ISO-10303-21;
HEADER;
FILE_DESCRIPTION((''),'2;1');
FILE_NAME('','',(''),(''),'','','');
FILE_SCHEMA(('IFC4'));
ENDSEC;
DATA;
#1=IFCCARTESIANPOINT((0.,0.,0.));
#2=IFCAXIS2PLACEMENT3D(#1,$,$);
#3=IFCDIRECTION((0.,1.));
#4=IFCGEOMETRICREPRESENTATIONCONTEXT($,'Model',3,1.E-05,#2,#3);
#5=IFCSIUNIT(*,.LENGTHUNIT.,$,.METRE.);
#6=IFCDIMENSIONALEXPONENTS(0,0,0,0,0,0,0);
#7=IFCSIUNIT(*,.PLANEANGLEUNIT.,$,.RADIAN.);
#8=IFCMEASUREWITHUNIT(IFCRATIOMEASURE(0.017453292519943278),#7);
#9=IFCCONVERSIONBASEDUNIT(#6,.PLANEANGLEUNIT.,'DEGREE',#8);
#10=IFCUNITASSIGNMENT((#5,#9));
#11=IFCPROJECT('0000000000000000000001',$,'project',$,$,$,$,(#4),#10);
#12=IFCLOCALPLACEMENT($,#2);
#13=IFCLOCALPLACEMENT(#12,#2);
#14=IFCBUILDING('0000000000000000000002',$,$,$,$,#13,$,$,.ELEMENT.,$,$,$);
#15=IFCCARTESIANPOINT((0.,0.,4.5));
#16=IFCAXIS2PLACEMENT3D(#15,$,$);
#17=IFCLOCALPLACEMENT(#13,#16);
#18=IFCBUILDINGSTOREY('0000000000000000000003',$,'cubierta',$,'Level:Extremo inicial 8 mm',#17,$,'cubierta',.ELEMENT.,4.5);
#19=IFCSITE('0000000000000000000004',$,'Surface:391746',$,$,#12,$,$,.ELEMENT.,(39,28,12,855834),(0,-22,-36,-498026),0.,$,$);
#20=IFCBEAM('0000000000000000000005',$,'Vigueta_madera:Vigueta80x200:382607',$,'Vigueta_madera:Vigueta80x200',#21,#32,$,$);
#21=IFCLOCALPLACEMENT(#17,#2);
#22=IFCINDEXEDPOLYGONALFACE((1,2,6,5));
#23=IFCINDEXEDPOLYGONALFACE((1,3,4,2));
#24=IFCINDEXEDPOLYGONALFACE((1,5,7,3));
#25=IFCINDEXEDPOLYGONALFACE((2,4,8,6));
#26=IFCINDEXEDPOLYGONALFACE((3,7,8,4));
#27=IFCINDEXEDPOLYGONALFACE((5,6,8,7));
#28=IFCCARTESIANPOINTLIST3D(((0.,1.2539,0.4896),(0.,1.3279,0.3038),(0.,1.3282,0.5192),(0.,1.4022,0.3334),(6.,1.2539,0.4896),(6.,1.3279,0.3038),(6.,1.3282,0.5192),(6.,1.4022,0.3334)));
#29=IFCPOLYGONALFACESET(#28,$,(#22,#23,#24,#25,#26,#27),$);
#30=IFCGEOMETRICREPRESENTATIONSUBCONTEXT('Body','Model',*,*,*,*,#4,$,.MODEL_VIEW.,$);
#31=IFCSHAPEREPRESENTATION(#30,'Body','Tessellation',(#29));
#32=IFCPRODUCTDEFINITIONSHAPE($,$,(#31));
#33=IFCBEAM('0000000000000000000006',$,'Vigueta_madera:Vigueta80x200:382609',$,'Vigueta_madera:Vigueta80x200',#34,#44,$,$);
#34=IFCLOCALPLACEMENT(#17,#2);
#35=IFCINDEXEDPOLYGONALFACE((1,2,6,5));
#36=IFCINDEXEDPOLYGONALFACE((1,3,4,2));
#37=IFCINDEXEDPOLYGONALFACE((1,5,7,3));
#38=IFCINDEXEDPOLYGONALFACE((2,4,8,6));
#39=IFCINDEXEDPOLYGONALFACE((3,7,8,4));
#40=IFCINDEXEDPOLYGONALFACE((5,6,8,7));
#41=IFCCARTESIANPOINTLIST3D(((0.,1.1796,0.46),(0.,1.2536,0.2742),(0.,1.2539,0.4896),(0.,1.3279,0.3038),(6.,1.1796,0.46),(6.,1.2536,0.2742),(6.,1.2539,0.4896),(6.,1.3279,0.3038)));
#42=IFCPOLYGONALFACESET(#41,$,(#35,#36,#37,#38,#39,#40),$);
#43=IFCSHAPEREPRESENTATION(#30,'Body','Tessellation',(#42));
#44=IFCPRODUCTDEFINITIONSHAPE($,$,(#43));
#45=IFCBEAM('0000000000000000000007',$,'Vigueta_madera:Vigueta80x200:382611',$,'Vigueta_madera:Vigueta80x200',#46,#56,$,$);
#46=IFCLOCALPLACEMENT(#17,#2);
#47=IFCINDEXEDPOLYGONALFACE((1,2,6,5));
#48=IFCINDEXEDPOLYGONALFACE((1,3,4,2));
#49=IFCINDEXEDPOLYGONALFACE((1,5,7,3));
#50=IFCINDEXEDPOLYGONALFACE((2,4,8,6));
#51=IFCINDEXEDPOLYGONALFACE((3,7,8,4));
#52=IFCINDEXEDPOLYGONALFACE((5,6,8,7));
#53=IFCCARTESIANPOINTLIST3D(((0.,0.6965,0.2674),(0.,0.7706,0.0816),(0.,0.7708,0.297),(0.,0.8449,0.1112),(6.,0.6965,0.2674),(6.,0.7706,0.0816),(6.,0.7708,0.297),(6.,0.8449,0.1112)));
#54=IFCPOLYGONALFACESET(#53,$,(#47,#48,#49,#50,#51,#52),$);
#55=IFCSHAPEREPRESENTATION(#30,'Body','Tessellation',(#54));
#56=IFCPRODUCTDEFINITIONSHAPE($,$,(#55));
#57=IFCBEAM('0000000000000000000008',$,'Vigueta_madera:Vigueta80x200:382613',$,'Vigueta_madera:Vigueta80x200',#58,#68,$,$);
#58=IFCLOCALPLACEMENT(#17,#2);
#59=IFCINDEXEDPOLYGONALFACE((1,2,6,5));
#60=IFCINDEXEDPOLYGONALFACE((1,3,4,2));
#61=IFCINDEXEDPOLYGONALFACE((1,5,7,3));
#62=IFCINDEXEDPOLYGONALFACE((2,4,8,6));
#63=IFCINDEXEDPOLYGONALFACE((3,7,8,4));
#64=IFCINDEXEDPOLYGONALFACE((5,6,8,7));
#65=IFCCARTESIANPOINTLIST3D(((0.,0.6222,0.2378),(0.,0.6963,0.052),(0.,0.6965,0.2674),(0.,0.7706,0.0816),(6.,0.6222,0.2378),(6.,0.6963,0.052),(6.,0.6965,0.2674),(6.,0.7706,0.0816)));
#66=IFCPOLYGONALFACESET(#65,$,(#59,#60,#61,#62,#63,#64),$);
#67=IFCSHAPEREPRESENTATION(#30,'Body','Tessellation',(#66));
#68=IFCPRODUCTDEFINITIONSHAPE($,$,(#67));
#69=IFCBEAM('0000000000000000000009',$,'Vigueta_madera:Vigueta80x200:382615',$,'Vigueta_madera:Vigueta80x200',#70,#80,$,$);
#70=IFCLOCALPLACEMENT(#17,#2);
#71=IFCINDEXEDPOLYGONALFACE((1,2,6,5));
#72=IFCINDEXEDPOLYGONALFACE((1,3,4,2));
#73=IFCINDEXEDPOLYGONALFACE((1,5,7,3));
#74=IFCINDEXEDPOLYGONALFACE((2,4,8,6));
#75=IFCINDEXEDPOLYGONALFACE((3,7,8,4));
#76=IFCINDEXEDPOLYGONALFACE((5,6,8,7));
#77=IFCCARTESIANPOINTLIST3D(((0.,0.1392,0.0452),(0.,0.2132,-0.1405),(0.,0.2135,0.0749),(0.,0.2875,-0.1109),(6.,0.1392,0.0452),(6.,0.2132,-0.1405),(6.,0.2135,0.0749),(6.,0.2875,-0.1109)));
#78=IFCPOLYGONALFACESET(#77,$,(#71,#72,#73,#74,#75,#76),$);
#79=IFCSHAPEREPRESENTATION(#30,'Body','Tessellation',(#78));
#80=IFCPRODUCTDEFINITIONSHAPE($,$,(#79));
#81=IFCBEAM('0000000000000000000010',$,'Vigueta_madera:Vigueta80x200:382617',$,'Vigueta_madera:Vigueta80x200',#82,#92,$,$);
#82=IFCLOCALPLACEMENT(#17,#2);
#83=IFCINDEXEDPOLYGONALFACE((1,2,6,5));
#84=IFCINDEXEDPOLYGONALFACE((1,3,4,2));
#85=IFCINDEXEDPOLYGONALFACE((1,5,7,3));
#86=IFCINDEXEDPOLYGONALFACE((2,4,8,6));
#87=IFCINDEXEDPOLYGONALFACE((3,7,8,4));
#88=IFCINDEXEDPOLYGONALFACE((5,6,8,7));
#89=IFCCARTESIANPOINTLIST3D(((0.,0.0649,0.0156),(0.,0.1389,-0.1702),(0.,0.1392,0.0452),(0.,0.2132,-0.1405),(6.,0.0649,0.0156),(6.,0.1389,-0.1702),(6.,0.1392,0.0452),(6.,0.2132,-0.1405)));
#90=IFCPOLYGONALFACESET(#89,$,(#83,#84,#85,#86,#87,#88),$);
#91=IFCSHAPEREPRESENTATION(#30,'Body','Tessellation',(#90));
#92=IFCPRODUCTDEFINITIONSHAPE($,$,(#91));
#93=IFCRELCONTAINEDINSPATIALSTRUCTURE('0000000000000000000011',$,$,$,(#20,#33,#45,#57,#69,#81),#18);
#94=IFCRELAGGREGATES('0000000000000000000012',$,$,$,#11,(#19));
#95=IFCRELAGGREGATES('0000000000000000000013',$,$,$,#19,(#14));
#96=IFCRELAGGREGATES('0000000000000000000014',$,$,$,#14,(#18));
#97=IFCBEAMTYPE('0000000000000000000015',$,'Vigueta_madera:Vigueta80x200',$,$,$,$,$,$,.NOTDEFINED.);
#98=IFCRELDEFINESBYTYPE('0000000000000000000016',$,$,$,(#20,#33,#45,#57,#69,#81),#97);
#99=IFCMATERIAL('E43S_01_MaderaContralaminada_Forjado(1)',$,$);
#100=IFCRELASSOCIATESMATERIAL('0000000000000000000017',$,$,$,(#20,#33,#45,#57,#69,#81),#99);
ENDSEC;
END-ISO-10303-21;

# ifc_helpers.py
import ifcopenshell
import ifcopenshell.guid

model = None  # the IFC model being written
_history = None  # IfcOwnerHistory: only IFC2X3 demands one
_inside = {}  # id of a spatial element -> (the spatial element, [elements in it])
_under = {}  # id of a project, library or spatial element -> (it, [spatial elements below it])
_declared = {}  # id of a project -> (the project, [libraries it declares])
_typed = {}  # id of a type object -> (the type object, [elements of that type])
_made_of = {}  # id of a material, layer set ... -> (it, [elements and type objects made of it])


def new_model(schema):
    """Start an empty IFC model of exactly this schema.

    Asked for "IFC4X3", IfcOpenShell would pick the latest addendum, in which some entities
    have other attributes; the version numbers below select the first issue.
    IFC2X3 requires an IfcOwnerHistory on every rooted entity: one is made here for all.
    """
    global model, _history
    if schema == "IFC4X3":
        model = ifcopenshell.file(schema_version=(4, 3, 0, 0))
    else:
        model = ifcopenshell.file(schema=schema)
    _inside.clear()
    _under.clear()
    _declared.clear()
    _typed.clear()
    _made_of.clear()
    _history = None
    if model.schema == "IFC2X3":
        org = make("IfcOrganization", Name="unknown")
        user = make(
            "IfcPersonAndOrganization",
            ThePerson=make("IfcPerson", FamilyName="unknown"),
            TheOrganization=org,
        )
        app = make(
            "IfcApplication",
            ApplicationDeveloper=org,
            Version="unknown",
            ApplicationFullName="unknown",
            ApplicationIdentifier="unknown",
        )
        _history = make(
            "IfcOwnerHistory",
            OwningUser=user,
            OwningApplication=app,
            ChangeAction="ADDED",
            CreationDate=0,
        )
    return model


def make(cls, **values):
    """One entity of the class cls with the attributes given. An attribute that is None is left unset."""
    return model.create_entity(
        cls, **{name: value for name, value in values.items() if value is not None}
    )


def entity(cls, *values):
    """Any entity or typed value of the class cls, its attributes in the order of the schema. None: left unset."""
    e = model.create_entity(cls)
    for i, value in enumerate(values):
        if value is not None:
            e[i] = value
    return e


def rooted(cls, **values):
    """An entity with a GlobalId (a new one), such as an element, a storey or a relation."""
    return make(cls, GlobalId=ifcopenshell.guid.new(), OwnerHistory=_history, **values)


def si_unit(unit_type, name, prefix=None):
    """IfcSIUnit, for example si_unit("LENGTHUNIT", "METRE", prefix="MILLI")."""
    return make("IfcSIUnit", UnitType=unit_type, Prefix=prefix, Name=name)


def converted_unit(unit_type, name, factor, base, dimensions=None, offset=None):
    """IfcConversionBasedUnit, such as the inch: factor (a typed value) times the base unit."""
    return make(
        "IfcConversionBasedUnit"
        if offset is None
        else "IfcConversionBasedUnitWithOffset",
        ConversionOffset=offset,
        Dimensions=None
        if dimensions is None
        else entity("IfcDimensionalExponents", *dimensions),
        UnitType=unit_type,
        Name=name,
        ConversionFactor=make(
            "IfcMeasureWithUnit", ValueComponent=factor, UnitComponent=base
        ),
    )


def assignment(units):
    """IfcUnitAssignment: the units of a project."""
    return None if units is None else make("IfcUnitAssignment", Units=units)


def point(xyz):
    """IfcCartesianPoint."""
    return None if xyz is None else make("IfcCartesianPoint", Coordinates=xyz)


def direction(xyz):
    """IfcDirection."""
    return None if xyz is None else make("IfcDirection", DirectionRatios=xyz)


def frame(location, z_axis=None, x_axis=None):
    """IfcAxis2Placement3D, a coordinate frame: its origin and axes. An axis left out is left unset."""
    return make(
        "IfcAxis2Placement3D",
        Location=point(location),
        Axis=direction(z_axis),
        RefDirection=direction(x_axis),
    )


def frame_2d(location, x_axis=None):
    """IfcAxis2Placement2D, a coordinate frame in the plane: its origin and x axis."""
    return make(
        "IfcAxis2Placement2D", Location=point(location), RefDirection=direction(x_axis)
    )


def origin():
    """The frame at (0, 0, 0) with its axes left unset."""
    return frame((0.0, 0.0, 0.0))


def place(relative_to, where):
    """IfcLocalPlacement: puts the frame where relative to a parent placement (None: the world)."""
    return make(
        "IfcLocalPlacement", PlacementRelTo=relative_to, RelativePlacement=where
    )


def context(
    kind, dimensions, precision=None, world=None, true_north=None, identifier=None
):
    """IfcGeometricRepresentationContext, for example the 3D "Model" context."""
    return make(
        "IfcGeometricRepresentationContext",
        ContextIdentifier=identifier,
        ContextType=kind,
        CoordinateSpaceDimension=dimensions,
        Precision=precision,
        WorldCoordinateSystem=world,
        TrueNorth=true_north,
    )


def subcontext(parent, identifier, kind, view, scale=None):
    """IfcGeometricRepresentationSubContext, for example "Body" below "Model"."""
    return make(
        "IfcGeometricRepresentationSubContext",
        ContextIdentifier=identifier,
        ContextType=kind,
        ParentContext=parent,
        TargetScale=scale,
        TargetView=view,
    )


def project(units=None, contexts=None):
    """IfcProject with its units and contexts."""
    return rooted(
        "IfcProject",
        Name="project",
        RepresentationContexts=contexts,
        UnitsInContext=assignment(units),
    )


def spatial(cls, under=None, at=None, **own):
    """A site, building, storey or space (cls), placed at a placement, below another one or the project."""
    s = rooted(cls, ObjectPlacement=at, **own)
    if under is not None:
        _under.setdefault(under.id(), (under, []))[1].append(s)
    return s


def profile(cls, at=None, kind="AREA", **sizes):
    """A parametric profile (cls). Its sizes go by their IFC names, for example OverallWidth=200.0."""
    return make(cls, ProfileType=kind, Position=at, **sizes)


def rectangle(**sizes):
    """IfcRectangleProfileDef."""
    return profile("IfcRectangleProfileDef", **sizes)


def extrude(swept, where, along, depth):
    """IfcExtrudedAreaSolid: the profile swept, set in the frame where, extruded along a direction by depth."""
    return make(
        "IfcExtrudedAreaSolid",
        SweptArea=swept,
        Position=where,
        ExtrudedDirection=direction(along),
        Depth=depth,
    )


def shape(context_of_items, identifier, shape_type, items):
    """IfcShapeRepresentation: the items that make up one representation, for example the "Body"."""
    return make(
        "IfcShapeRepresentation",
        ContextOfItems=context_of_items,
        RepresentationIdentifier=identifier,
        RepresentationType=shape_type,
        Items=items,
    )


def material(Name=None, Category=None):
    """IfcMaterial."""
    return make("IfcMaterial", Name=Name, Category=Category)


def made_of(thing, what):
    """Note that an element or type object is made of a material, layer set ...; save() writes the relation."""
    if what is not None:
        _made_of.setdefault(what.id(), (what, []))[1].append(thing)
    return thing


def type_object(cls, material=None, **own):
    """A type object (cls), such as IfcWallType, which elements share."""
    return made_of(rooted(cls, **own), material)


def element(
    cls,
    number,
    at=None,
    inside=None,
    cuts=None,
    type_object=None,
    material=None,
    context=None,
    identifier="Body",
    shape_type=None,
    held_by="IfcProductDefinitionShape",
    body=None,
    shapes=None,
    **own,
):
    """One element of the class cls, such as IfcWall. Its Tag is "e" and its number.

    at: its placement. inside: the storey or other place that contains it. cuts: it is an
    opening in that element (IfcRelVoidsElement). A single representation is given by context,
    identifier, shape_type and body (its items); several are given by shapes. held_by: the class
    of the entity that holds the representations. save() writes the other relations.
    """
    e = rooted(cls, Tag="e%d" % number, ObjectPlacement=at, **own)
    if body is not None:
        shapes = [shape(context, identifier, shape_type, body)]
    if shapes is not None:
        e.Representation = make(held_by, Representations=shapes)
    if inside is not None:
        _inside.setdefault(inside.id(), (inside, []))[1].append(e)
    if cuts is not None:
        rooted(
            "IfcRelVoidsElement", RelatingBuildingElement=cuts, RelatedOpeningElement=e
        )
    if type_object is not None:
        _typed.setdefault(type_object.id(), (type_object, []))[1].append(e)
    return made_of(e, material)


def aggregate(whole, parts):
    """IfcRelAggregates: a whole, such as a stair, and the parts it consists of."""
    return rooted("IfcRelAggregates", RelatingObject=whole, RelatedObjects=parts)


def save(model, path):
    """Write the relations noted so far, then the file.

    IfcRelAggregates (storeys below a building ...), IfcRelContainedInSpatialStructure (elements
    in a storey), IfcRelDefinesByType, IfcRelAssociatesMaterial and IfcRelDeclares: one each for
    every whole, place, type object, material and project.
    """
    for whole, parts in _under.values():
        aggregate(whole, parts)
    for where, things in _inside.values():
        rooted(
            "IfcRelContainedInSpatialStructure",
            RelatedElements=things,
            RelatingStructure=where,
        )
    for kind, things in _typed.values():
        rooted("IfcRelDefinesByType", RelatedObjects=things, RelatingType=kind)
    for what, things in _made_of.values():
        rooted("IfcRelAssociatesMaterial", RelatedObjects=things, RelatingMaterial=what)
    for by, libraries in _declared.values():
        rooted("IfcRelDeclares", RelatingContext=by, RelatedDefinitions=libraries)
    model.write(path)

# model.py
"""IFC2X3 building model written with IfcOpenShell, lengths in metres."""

from ifc_helpers import new_model, entity, si_unit, converted_unit, direction, frame, frame_2d, origin, place, context, subcontext, project, spatial, rectangle, extrude, material, type_object, element, save


model = new_model("IFC2X3")

# Units and contexts
model_context = context("Model", 3, precision=1e-05, world=origin(), true_north=direction((0.0, 1.0)))
body_context = subcontext(model_context, "Body", "Model", "MODEL_VIEW")
ifc_project = project(units=[si_unit("LENGTHUNIT", "METRE"), converted_unit("PLANEANGLEUNIT", "DEGREE", entity("IfcRatioMeasure", 0.017453292519943278), si_unit("PLANEANGLEUNIT", "RADIAN"), dimensions=[0, 0, 0, 0, 0, 0, 0])], contexts=[model_context])

# Site, building, storey
site_placement = place(None, origin())
site = spatial("IfcSite", under=ifc_project, at=site_placement, Name="Surface:391746", CompositionType="ELEMENT", RefLatitude=(39, 28, 12, 855834), RefLongitude=(0, -22, -36, -498026), RefElevation=0.0)
building_placement = place(site_placement, origin())
building = spatial("IfcBuilding", under=site, at=building_placement, CompositionType="ELEMENT")
storey_placement = place(building_placement, frame((0.0, 0.0, 4.5)))
storey = spatial("IfcBuildingStorey", under=building, at=storey_placement, Name="cubierta", ObjectType="Level:Extremo inicial 8 mm", LongName="cubierta", CompositionType="ELEMENT", Elevation=4.5)

# Beams
ifc_material = material(Name="E43S_01_MaderaContralaminada_Forjado(1)")
beam_type = type_object("IfcBeamType", Name="Vigueta_madera:Vigueta80x200", PredefinedType="NOTDEFINED")
beam_1_placement = place(storey_placement, frame((0.0, 1.291, 0.5044)))
element("IfcBeam", 1, at=beam_1_placement, inside=storey, type_object=beam_type, material=ifc_material, Name="Vigueta_madera:Vigueta80x200:382607", ObjectType="Vigueta_madera:Vigueta80x200", context=body_context, shape_type="SweptSolid", body=[
    extrude(rectangle(XDim=0.2, YDim=0.08, at=frame_2d((0.0, 0.0), x_axis=(1.0, 0.0))), frame((0.0, 0.037, -0.0929), z_axis=(1.0, 0.0, 0.0), x_axis=(0.0, -0.370233, 0.928939)), (0.0, 0.0, 1.0), 6.0),
])
beam_2_placement = place(storey_placement, frame((0.0, 1.2167, 0.4748)))
element("IfcBeam", 2, at=beam_2_placement, inside=storey, type_object=beam_type, material=ifc_material, Name="Vigueta_madera:Vigueta80x200:382609", ObjectType="Vigueta_madera:Vigueta80x200", context=body_context, shape_type="SweptSolid", body=[
    extrude(rectangle(XDim=0.2, YDim=0.08, at=frame_2d((0.0, 0.0), x_axis=(1.0, 0.0))), frame((0.0, 0.037, -0.0929), z_axis=(1.0, 0.0, 0.0), x_axis=(0.0, -0.370233, 0.928939)), (0.0, 0.0, 1.0), 6.0),
])
beam_3_placement = place(storey_placement, frame((0.0, 0.7337, 0.2822)))
element("IfcBeam", 3, at=beam_3_placement, inside=storey, type_object=beam_type, material=ifc_material, Name="Vigueta_madera:Vigueta80x200:382611", ObjectType="Vigueta_madera:Vigueta80x200", context=body_context, shape_type="SweptSolid", body=[
    extrude(rectangle(XDim=0.2, YDim=0.08, at=frame_2d((0.0, 0.0), x_axis=(1.0, 0.0))), frame((0.0, 0.037, -0.0929), z_axis=(1.0, 0.0, 0.0), x_axis=(0.0, -0.370233, 0.928939)), (0.0, 0.0, 1.0), 6.0),
])
beam_4_placement = place(storey_placement, frame((0.0, 0.6594, 0.2526)))
element("IfcBeam", 4, at=beam_4_placement, inside=storey, type_object=beam_type, material=ifc_material, Name="Vigueta_madera:Vigueta80x200:382613", ObjectType="Vigueta_madera:Vigueta80x200", context=body_context, shape_type="SweptSolid", body=[
    extrude(rectangle(XDim=0.2, YDim=0.08, at=frame_2d((0.0, 0.0), x_axis=(1.0, 0.0))), frame((0.0, 0.037, -0.0929), z_axis=(1.0, 0.0, 0.0), x_axis=(0.0, -0.370233, 0.928939)), (0.0, 0.0, 1.0), 6.0),
])
beam_5_placement = place(storey_placement, frame((0.0, 0.1763, 0.0601)))
element("IfcBeam", 5, at=beam_5_placement, inside=storey, type_object=beam_type, material=ifc_material, Name="Vigueta_madera:Vigueta80x200:382615", ObjectType="Vigueta_madera:Vigueta80x200", context=body_context, shape_type="SweptSolid", body=[
    extrude(rectangle(XDim=0.2, YDim=0.08, at=frame_2d((0.0, 0.0), x_axis=(1.0, 0.0))), frame((0.0, 0.037, -0.0929), z_axis=(1.0, 0.0, 0.0), x_axis=(0.0, -0.370233, 0.928939)), (0.0, 0.0, 1.0), 6.0),
])
beam_6_placement = place(storey_placement, frame((0.0, 0.102, 0.0304)))
element("IfcBeam", 6, at=beam_6_placement, inside=storey, type_object=beam_type, material=ifc_material, Name="Vigueta_madera:Vigueta80x200:382617", ObjectType="Vigueta_madera:Vigueta80x200", context=body_context, shape_type="SweptSolid", body=[
    extrude(rectangle(XDim=0.2, YDim=0.08, at=frame_2d((0.0, 0.0), x_axis=(1.0, 0.0))), frame((0.0, 0.037, -0.0929), z_axis=(1.0, 0.0, 0.0), x_axis=(0.0, -0.370233, 0.928939)), (0.0, 0.0, 1.0), 6.0),
])

save(model, "model.ifc")
